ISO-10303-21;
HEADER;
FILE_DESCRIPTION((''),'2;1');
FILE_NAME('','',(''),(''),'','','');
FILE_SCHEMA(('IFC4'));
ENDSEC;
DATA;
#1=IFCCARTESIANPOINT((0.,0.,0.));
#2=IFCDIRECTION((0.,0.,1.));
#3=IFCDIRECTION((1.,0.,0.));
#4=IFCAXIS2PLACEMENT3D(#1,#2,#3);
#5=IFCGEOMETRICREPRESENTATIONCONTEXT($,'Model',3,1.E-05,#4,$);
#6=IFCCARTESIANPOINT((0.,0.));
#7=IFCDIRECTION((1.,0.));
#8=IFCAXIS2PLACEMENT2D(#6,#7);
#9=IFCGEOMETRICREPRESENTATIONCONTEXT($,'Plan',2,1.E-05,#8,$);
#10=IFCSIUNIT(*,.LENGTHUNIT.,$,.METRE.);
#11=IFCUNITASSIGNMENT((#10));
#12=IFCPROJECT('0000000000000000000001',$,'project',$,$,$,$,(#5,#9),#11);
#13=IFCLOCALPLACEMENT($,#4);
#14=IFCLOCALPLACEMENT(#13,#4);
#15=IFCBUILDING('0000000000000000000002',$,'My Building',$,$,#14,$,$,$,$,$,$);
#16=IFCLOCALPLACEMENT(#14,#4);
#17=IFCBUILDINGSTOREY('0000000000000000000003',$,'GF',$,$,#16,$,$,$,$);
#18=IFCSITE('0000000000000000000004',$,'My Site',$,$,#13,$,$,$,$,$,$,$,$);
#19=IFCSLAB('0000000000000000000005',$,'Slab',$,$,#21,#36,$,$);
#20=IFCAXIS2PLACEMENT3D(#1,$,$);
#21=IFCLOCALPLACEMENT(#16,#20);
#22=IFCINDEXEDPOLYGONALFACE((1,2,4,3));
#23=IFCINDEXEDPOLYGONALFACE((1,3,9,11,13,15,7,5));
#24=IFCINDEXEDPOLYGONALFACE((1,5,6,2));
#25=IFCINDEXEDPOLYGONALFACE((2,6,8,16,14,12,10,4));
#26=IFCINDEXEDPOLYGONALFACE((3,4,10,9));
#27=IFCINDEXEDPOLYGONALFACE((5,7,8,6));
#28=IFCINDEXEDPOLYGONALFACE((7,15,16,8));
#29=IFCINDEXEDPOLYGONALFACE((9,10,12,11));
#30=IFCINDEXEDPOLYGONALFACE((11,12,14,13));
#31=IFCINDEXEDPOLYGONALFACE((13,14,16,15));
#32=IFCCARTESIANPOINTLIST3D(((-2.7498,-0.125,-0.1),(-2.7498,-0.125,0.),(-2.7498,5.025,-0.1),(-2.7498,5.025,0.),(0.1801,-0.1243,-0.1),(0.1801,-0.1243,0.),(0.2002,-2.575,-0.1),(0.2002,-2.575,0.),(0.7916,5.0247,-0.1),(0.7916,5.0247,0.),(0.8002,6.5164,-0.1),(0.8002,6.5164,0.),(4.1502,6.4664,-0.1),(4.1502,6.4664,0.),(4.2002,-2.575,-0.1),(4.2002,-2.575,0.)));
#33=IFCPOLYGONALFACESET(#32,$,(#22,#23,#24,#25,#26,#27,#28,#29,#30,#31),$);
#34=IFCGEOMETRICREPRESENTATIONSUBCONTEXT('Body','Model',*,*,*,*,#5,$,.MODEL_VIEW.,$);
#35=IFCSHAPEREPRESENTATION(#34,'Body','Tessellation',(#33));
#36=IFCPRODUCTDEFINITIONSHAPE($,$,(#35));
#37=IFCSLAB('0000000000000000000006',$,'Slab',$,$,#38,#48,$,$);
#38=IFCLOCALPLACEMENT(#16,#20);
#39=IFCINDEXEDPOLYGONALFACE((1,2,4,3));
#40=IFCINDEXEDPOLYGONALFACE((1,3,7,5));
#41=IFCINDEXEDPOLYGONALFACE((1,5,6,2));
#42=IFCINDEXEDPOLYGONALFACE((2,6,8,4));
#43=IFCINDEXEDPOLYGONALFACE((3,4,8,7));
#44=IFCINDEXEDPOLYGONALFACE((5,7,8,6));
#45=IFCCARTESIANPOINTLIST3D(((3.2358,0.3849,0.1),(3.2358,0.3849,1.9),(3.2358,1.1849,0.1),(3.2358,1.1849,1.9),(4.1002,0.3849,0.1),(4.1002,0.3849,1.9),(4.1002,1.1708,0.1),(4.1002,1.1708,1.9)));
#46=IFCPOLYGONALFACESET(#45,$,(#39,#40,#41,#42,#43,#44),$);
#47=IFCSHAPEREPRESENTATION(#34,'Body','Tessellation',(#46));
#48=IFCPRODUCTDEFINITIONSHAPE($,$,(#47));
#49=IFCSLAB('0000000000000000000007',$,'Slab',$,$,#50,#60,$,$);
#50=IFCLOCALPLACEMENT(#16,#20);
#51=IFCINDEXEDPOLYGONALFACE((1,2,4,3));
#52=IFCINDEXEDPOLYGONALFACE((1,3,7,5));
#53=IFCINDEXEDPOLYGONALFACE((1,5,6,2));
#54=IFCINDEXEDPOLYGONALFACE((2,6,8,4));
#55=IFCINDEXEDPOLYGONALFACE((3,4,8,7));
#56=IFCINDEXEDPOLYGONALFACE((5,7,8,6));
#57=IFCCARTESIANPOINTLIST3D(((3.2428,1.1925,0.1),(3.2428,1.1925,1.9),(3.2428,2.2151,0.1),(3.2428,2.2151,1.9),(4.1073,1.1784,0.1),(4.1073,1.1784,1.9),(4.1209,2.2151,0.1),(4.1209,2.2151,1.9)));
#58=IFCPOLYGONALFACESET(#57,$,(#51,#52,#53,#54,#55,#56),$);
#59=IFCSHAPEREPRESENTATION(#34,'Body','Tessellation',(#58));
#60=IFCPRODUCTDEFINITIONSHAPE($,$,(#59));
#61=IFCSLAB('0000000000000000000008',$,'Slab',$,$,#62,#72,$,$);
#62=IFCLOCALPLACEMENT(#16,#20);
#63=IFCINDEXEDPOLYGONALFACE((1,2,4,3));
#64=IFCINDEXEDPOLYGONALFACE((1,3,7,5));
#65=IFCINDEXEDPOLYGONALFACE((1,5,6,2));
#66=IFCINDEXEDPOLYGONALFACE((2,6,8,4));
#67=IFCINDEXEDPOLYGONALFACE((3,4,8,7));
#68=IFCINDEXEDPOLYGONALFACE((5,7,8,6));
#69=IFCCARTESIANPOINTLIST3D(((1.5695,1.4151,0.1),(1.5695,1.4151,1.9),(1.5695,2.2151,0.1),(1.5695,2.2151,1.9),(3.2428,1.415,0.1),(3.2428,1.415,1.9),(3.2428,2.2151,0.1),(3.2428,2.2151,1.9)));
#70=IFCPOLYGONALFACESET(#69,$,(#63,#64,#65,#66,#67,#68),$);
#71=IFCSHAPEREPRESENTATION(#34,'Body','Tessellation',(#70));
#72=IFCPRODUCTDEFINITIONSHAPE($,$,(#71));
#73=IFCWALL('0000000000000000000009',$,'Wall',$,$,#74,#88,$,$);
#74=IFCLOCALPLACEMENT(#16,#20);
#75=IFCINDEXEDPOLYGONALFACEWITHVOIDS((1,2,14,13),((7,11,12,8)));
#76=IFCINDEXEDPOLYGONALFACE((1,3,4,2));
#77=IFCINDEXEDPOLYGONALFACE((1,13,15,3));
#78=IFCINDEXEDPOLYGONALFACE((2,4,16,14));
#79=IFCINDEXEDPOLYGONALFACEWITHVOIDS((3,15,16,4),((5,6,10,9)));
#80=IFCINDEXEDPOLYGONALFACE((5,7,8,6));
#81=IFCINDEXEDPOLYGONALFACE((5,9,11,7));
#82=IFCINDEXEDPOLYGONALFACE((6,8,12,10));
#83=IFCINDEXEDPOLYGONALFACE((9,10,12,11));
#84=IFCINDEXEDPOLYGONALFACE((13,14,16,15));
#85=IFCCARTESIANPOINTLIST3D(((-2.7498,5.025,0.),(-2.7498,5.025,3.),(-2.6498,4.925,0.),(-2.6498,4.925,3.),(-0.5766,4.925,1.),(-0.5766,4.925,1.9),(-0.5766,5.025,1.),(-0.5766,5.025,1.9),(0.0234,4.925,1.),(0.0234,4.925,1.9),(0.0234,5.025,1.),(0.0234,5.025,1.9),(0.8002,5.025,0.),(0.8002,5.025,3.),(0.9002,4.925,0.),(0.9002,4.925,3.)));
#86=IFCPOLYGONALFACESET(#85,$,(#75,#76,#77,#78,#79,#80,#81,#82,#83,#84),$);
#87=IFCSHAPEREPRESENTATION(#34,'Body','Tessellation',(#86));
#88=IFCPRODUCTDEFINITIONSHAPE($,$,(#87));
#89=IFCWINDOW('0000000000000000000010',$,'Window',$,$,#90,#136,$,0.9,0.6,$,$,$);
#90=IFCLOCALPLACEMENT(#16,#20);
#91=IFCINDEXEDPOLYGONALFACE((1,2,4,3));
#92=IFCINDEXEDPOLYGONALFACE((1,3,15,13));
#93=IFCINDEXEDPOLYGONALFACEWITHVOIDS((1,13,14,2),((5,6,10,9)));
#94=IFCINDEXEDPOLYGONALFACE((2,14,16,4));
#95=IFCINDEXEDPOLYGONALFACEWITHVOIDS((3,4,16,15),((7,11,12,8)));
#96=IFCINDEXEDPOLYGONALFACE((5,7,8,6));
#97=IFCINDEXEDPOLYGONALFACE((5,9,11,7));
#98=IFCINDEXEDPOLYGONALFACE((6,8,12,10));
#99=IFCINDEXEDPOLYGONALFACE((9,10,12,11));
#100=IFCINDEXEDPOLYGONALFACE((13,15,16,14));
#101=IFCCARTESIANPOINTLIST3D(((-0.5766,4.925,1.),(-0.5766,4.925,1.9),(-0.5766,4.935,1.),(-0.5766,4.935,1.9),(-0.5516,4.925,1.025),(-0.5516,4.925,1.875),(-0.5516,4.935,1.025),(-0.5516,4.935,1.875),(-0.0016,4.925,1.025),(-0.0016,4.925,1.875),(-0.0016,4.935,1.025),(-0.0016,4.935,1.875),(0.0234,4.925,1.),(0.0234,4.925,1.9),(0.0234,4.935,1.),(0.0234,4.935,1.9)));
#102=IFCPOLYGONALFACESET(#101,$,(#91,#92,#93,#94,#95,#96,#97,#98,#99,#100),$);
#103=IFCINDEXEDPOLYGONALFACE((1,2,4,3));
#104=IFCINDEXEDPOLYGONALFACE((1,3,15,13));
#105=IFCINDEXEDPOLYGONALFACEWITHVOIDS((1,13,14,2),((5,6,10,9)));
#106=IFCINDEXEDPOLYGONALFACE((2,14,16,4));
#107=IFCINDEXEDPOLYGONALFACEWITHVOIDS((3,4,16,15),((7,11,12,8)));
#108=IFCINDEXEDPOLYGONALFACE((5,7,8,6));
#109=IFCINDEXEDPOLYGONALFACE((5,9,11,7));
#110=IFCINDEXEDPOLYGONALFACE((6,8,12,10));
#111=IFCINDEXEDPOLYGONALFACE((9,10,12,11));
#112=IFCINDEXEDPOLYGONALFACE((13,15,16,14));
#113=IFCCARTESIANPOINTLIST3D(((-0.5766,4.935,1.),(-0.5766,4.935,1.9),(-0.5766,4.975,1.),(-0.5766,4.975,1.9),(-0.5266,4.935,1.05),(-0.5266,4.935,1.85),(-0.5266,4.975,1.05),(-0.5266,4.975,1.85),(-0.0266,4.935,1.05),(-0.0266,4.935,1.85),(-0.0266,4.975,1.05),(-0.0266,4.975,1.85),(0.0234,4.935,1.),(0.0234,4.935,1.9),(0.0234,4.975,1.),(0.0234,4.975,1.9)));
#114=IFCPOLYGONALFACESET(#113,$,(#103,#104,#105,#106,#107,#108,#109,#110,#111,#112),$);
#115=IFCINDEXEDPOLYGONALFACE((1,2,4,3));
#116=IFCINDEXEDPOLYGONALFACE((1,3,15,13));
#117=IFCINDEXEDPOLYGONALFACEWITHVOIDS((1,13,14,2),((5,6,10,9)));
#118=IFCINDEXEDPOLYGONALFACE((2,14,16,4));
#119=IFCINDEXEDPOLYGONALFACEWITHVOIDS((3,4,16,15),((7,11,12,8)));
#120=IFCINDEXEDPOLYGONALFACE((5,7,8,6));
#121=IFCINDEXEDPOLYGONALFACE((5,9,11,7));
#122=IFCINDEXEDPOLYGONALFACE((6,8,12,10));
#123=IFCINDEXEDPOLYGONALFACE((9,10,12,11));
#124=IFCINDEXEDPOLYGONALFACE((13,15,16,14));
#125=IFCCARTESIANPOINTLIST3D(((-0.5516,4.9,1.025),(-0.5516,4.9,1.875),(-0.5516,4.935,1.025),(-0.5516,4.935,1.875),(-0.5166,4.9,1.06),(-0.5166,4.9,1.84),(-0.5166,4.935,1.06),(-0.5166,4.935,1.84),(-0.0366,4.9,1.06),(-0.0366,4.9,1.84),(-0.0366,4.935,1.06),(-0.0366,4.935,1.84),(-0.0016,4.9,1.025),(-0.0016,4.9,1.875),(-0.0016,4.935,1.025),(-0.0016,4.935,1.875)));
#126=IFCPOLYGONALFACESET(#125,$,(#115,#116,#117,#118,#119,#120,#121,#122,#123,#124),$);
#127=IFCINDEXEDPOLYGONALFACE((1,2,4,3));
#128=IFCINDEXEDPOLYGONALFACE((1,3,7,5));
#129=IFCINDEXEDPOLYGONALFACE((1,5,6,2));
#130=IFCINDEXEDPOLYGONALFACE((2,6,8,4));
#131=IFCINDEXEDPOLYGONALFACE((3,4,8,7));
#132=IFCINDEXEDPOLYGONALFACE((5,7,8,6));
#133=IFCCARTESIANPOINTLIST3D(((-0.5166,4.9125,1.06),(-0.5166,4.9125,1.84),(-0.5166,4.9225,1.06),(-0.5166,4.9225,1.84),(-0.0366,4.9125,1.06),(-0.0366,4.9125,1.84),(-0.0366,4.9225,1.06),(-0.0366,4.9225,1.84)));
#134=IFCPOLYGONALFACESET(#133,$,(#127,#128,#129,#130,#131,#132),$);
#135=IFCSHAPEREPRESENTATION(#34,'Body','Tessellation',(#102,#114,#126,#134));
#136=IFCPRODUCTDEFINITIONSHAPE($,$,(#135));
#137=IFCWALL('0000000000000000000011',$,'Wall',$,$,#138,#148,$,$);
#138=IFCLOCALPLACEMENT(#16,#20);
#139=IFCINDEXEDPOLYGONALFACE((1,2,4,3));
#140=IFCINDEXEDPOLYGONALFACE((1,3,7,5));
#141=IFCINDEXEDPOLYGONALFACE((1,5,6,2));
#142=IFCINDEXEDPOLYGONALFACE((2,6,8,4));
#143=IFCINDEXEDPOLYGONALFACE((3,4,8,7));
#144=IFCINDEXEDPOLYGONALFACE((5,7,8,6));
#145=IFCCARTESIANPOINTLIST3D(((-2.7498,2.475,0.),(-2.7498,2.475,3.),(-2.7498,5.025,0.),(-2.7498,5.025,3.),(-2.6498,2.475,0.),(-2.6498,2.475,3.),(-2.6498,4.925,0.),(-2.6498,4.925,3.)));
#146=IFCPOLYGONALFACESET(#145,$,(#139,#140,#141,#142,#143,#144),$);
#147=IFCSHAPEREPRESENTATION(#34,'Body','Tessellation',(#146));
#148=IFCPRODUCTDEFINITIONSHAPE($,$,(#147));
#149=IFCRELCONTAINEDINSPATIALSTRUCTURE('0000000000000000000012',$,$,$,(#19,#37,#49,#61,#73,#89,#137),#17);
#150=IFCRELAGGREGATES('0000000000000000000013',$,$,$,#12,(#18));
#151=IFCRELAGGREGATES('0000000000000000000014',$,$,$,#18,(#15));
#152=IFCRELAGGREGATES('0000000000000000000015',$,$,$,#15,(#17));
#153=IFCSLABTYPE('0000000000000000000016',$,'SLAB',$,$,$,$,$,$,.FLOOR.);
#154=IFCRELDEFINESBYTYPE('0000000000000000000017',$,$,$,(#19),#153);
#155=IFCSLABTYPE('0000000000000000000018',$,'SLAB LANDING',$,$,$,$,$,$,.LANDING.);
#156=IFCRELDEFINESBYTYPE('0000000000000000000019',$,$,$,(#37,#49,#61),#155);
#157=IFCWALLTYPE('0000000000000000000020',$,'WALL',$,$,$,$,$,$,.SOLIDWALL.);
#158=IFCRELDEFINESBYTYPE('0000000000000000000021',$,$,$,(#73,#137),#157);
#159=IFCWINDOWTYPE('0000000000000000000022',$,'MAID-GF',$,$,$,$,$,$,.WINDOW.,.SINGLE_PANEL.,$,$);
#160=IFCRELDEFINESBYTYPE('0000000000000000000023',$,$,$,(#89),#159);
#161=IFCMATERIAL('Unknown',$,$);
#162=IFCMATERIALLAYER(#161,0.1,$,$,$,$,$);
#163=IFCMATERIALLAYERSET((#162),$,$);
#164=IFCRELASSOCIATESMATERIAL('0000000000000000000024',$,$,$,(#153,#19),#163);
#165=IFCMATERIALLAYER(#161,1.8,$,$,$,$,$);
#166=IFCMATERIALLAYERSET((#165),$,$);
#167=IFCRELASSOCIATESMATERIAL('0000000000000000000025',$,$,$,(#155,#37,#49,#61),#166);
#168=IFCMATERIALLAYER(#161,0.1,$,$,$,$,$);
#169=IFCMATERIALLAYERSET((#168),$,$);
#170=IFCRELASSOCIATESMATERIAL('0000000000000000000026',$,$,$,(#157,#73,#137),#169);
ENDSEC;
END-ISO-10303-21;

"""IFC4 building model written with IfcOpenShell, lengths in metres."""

from ifc_helpers import new_model, entity, si_unit, frame, origin_with_axes, origin_2d_with_axis, place, context, subcontext, project, spatial, line, indexed_curve, outline, extrude, shape, source, transform, mapped, material, layer, layer_set, layer_usage, type_object, type_shapes, element, fill, save


model = new_model("IFC4")

# Units and contexts
model_context = context("Model", 3, precision=1e-05, world=origin_with_axes())
plan_context = context("Plan", 2, precision=1e-05, world=origin_2d_with_axis())
body_context_1 = subcontext(model_context, "Body", "Model", "MODEL_VIEW")
body_context_2 = subcontext(plan_context, "Body", "Plan", "PLAN_VIEW")
ifc_project = project(units=[si_unit("LENGTHUNIT", "METRE")], contexts=[model_context, plan_context])

# Site, building, storey
site_placement = place(None, origin_with_axes())
site = spatial("IfcSite", under=ifc_project, at=site_placement, Name="My Site")
building_placement = place(site_placement, origin_with_axes())
building = spatial("IfcBuilding", under=site, at=building_placement, Name="My Building")
storey_placement = place(building_placement, origin_with_axes())
storey = spatial("IfcBuildingStorey", under=building, at=storey_placement, Name="GF")

# Slabs
ifc_material_1 = material(Name="Unknown")
ifc_layer_1 = layer(ifc_material_1, 0.1)
ifc_layer_set_1 = layer_set([ifc_layer_1])
ifc_layer_usage_1 = layer_usage(ifc_layer_set_1, "AXIS3", "POSITIVE", -0.1)
slab_type_1 = type_object("IfcSlabType", Name="SLAB", PredefinedType="FLOOR", material=ifc_layer_set_1)
slab_1_placement = place(storey_placement, frame((0.2002, -2.575, 0.0), z_axis=(0.0, 0.0, 1.0), x_axis=(1.0, 0.0, 0.0)))
element("IfcSlab", 1, at=slab_1_placement, inside=storey, type_object=slab_type_1, material=ifc_layer_usage_1, Name="Slab", context=body_context_1, shape_type="SweptSolid", body=[
    extrude(outline(indexed_curve([(0.0, 0.0), (4.0, 0.0), (3.95, 9.0414), (0.6, 9.0914), (0.5914, 7.5997), (-2.95, 7.6), (-2.95, 2.45), (-0.0201, 2.4507), (0.0, 0.0)])), frame((0.0, 0.0, -0.1), z_axis=(0.0, 0.0, 1.0), x_axis=(1.0, 0.0, 0.0)), (0.0, 0.0, 1.0), 0.1),
])
ifc_layer_2 = layer(ifc_material_1, 1.8)
ifc_layer_set_2 = layer_set([ifc_layer_2])
ifc_layer_usage_2 = layer_usage(ifc_layer_set_2, "AXIS3", "POSITIVE", -0.1)
slab_type_2 = type_object("IfcSlabType", Name="SLAB LANDING", PredefinedType="LANDING", material=ifc_layer_set_2)
slab_2_placement = place(storey_placement, frame((3.2358, 1.1849, 0.2), z_axis=(0.0, 0.0, 1.0), x_axis=(1.0, 0.0, 0.0)))
element("IfcSlab", 2, at=slab_2_placement, inside=storey, type_object=slab_type_2, material=ifc_layer_usage_2, Name="Slab", context=body_context_1, shape_type="SweptSolid", body=[
    extrude(outline(indexed_curve([(0.0, 0.0), (0.0, -0.8), (0.8645, -0.8), (0.8645, -0.0141), (0.0, 0.0)])), frame((0.0, 0.0, -0.1), z_axis=(0.0, 0.0, 1.0), x_axis=(1.0, 0.0, 0.0)), (0.0, 0.0, 1.0), 1.8),
])
ifc_layer_usage_3 = layer_usage(ifc_layer_set_2, "AXIS3", "POSITIVE", -1.8)
slab_3_placement = place(storey_placement, frame((3.2428, 1.1925, 1.9), z_axis=(0.0, 0.0, 1.0), x_axis=(1.0, 0.0, 0.0)))
element("IfcSlab", 3, at=slab_3_placement, inside=storey, type_object=slab_type_2, material=ifc_layer_usage_3, Name="Slab", context=body_context_1, shape_type="SweptSolid", body=[
    extrude(outline(indexed_curve([(0.0, 0.0), (0.0, 1.0226), (0.8781, 1.0226), (0.8645, -0.0141), (0.0, 0.0)])), frame((0.0, 0.0, -1.8), z_axis=(0.0, 0.0, 1.0), x_axis=(1.0, 0.0, 0.0)), (0.0, 0.0, 1.0), 1.8),
])
ifc_layer_usage_4 = layer_usage(ifc_layer_set_2, "AXIS3", "POSITIVE", -1.8)
slab_4_placement = place(storey_placement, frame((1.5695, 2.2151, 1.9), z_axis=(0.0, 0.0, 1.0), x_axis=(1.0, 0.0, 0.0)))
element("IfcSlab", 4, at=slab_4_placement, inside=storey, type_object=slab_type_2, material=ifc_layer_usage_4, Name="Slab", context=body_context_1, shape_type="SweptSolid", body=[
    extrude(outline(indexed_curve([(0.0, 0.0), (1.6733, 0.0), (1.6733, -0.8), (0.0, -0.8), (0.0, 0.0)])), frame((0.0, 0.0, -1.8), z_axis=(0.0, 0.0, 1.0), x_axis=(1.0, 0.0, 0.0)), (0.0, 0.0, 1.0), 1.8),
])

# Wall, opening, window
ifc_layer_3 = layer(ifc_material_1, 0.1)
ifc_layer_set_3 = layer_set([ifc_layer_3])
ifc_layer_usage_5 = layer_usage(ifc_layer_set_3, "AXIS2", "POSITIVE", 0.0)
wall_type = type_object("IfcWallType", Name="WALL", PredefinedType="SOLIDWALL", material=ifc_layer_set_3)
wall_1_placement = place(storey_placement, frame((0.8002, 5.025, 0.0), z_axis=(0.0, 0.0, 1.0), x_axis=(-1.0, 0.0, 0.0)))
wall_1 = element("IfcWall", 5, at=wall_1_placement, inside=storey, type_object=wall_type, material=ifc_layer_usage_5, Name="Wall", context=body_context_1, shape_type="SweptSolid", body=[
    extrude(outline(indexed_curve([(0.0, 0.0), (-0.1, 0.1), (3.45, 0.1), (3.55, 0.0)], segments=[line(1, 2, 3, 4, 1)])), origin_with_axes(), (0.0, 0.0, 1.0), 3.0),
])
shared_shape_1 = source(origin_with_axes(), body_context_1, "Body", "SweptSolid", [
    extrude(outline(indexed_curve([(0.0, 0.0), (0.6, 0.0), (0.6, 0.9), (0.0, 0.9)], segments=[line(1, 2, 3, 4, 1)])), frame((0.0, -0.6, 0.0), z_axis=(0.0, -1.0, 0.0), x_axis=(1.0, 0.0, 0.0)), (0.0, 0.0, -1.0), 1.2),
])
opening_1_placement = place(wall_1_placement, frame((0.7768, 0.0, 1.0), z_axis=(0.0, 0.0, 1.0), x_axis=(1.0, -0.000001, 0.0)))
opening_1 = element("IfcOpeningElement", 6, at=opening_1_placement, cuts=wall_1, PredefinedType="OPENING", context=body_context_1, shape_type="MappedRepresentation", body=[
    mapped(shared_shape_1, transform((0.0, 0.0, 0.0), x_axis=(1.0, 0.0, 0.0), y_axis=(0.0, 1.0, 0.0), z_axis=(0.0, 0.0, 1.0), scale=1.0)),
])
window_type_1 = type_object("IfcWindowType", Name="MAID-GF", PartitioningType="SINGLE_PANEL", PredefinedType="WINDOW")
shared_shape_2 = source(origin_with_axes(), body_context_1, "Body", "SweptSolid", [
    extrude(outline(indexed_curve([(0.0, 0.0), (0.6, 0.0), (0.6, 0.9), (0.0, 0.9)], segments=[line(1, 2, 3, 4, 1)]), holes=[indexed_curve([(0.025, 0.025), (0.575, 0.025), (0.575, 0.875), (0.025, 0.875)], segments=[line(1, 2, 3, 4, 1)])]), frame((0.0, 0.09, 0.0), z_axis=(0.0, -1.0, 0.0), x_axis=(1.0, 0.0, 0.0)), (0.0, 0.0, -1.0), 0.01),
    extrude(outline(indexed_curve([(0.0, 0.0), (0.6, 0.0), (0.6, 0.9), (0.0, 0.9)], segments=[line(1, 2, 3, 4, 1)]), holes=[indexed_curve([(0.05, 0.05), (0.55, 0.05), (0.55, 0.85), (0.05, 0.85)], segments=[line(1, 2, 3, 4, 1)])]), frame((0.0, 0.05, 0.0), z_axis=(0.0, -1.0, 0.0), x_axis=(1.0, 0.0, 0.0)), (0.0, 0.0, -1.0), 0.04),
    extrude(outline(indexed_curve([(0.0, 0.0), (0.55, 0.0), (0.55, 0.85), (0.0, 0.85)], segments=[line(1, 2, 3, 4, 1)]), holes=[indexed_curve([(0.035, 0.035), (0.515, 0.035), (0.515, 0.815), (0.035, 0.815)], segments=[line(1, 2, 3, 4, 1)])]), frame((0.025, 0.09, 0.025), z_axis=(0.0, -1.0, 0.0), x_axis=(1.0, 0.0, 0.0)), (0.0, 0.0, -1.0), 0.035),
    extrude(outline(indexed_curve([(0.035, 0.035), (0.515, 0.035), (0.515, 0.815), (0.035, 0.815)], segments=[line(1, 2, 3, 4, 1)])), frame((0.025, 0.1025, 0.025), z_axis=(0.0, -1.0, 0.0), x_axis=(1.0, 0.0, 0.0)), (0.0, 0.0, -1.0), 0.01),
])
shared_shape_3 = source(origin_with_axes(), body_context_2, "Body", "Curve2D", [
    entity("IfcIndexedPolyCurve", entity("IfcCartesianPointList2D", [[0.05, 0.05], [0.55, 0.05]])),
    entity("IfcIndexedPolyCurve", entity("IfcCartesianPointList2D", [[0.0, 0.1], [0.025, 0.1], [0.025, 0.09], [0.05, 0.09], [0.05, 0.05], [0.0, 0.05]]), [entity("IfcLineIndex", [1, 2, 3, 4, 5, 6, 1])]),
    entity("IfcIndexedPolyCurve", entity("IfcCartesianPointList2D", [[0.6, 0.1], [0.575, 0.1], [0.575, 0.09], [0.55, 0.09], [0.55, 0.05], [0.6, 0.05]]), [entity("IfcLineIndex", [1, 2, 3, 4, 5, 6, 1])]),
    entity("IfcIndexedPolyCurve", entity("IfcCartesianPointList2D", [[0.025, 0.09], [0.06, 0.09], [0.06, 0.125], [0.025, 0.125]]), [entity("IfcLineIndex", [1, 2, 3, 4, 1])]),
    entity("IfcIndexedPolyCurve", entity("IfcCartesianPointList2D", [[0.575, 0.09], [0.54, 0.09], [0.54, 0.125], [0.575, 0.125]]), [entity("IfcLineIndex", [1, 2, 3, 4, 1])]),
    entity("IfcIndexedPolyCurve", entity("IfcCartesianPointList2D", [[0.06, 0.09], [0.54, 0.09]])),
    entity("IfcIndexedPolyCurve", entity("IfcCartesianPointList2D", [[0.06, 0.125], [0.54, 0.125]])),
    entity("IfcIndexedPolyCurve", entity("IfcCartesianPointList2D", [[0.06, 0.1075], [0.54, 0.1075]])),
])
type_shapes(window_type_1, [shared_shape_2, shared_shape_3])
window_1_placement = place(opening_1_placement, frame((0.0, 0.0, 0.0), z_axis=(0.0, 0.0, 1.0), x_axis=(1.0, 0.0, 0.0)))
window_1 = element("IfcWindow", 7, at=window_1_placement, inside=storey, type_object=window_type_1, Name="Window", OverallHeight=0.9, OverallWidth=0.6, shapes=[
    shape(body_context_1, "Body", "MappedRepresentation", [mapped(shared_shape_2, transform((0.0, 0.0, 0.0), x_axis=(1.0, 0.0, 0.0), y_axis=(0.0, 1.0, 0.0), z_axis=(0.0, 0.0, 1.0), scale=1.0))]),
    shape(body_context_2, "Body", "MappedRepresentation", [mapped(shared_shape_3, transform((0.0, 0.0, 0.0), x_axis=(1.0, 0.0, 0.0), y_axis=(0.0, 1.0, 0.0), z_axis=(0.0, 0.0, 1.0), scale=1.0))]),
])
fill(opening_1, window_1)

# Wall
ifc_layer_usage_6 = layer_usage(ifc_layer_set_3, "AXIS2", "POSITIVE", 0.0)
wall_2_placement = place(storey_placement, frame((-2.7498, 5.025, 0.0), z_axis=(0.0, 0.0, 1.0), x_axis=(0.0, -1.0, 0.0)))
element("IfcWall", 8, at=wall_2_placement, inside=storey, type_object=wall_type, material=ifc_layer_usage_6, Name="Wall", context=body_context_1, shape_type="SweptSolid", body=[
    extrude(outline(indexed_curve([(0.0, 0.0), (0.1, 0.1), (2.55, 0.1), (2.55, 0.0)], segments=[line(1, 2, 3, 4, 1)])), origin_with_axes(), (0.0, 0.0, 1.0), 3.0),
])

save(model, "model.ifc")
